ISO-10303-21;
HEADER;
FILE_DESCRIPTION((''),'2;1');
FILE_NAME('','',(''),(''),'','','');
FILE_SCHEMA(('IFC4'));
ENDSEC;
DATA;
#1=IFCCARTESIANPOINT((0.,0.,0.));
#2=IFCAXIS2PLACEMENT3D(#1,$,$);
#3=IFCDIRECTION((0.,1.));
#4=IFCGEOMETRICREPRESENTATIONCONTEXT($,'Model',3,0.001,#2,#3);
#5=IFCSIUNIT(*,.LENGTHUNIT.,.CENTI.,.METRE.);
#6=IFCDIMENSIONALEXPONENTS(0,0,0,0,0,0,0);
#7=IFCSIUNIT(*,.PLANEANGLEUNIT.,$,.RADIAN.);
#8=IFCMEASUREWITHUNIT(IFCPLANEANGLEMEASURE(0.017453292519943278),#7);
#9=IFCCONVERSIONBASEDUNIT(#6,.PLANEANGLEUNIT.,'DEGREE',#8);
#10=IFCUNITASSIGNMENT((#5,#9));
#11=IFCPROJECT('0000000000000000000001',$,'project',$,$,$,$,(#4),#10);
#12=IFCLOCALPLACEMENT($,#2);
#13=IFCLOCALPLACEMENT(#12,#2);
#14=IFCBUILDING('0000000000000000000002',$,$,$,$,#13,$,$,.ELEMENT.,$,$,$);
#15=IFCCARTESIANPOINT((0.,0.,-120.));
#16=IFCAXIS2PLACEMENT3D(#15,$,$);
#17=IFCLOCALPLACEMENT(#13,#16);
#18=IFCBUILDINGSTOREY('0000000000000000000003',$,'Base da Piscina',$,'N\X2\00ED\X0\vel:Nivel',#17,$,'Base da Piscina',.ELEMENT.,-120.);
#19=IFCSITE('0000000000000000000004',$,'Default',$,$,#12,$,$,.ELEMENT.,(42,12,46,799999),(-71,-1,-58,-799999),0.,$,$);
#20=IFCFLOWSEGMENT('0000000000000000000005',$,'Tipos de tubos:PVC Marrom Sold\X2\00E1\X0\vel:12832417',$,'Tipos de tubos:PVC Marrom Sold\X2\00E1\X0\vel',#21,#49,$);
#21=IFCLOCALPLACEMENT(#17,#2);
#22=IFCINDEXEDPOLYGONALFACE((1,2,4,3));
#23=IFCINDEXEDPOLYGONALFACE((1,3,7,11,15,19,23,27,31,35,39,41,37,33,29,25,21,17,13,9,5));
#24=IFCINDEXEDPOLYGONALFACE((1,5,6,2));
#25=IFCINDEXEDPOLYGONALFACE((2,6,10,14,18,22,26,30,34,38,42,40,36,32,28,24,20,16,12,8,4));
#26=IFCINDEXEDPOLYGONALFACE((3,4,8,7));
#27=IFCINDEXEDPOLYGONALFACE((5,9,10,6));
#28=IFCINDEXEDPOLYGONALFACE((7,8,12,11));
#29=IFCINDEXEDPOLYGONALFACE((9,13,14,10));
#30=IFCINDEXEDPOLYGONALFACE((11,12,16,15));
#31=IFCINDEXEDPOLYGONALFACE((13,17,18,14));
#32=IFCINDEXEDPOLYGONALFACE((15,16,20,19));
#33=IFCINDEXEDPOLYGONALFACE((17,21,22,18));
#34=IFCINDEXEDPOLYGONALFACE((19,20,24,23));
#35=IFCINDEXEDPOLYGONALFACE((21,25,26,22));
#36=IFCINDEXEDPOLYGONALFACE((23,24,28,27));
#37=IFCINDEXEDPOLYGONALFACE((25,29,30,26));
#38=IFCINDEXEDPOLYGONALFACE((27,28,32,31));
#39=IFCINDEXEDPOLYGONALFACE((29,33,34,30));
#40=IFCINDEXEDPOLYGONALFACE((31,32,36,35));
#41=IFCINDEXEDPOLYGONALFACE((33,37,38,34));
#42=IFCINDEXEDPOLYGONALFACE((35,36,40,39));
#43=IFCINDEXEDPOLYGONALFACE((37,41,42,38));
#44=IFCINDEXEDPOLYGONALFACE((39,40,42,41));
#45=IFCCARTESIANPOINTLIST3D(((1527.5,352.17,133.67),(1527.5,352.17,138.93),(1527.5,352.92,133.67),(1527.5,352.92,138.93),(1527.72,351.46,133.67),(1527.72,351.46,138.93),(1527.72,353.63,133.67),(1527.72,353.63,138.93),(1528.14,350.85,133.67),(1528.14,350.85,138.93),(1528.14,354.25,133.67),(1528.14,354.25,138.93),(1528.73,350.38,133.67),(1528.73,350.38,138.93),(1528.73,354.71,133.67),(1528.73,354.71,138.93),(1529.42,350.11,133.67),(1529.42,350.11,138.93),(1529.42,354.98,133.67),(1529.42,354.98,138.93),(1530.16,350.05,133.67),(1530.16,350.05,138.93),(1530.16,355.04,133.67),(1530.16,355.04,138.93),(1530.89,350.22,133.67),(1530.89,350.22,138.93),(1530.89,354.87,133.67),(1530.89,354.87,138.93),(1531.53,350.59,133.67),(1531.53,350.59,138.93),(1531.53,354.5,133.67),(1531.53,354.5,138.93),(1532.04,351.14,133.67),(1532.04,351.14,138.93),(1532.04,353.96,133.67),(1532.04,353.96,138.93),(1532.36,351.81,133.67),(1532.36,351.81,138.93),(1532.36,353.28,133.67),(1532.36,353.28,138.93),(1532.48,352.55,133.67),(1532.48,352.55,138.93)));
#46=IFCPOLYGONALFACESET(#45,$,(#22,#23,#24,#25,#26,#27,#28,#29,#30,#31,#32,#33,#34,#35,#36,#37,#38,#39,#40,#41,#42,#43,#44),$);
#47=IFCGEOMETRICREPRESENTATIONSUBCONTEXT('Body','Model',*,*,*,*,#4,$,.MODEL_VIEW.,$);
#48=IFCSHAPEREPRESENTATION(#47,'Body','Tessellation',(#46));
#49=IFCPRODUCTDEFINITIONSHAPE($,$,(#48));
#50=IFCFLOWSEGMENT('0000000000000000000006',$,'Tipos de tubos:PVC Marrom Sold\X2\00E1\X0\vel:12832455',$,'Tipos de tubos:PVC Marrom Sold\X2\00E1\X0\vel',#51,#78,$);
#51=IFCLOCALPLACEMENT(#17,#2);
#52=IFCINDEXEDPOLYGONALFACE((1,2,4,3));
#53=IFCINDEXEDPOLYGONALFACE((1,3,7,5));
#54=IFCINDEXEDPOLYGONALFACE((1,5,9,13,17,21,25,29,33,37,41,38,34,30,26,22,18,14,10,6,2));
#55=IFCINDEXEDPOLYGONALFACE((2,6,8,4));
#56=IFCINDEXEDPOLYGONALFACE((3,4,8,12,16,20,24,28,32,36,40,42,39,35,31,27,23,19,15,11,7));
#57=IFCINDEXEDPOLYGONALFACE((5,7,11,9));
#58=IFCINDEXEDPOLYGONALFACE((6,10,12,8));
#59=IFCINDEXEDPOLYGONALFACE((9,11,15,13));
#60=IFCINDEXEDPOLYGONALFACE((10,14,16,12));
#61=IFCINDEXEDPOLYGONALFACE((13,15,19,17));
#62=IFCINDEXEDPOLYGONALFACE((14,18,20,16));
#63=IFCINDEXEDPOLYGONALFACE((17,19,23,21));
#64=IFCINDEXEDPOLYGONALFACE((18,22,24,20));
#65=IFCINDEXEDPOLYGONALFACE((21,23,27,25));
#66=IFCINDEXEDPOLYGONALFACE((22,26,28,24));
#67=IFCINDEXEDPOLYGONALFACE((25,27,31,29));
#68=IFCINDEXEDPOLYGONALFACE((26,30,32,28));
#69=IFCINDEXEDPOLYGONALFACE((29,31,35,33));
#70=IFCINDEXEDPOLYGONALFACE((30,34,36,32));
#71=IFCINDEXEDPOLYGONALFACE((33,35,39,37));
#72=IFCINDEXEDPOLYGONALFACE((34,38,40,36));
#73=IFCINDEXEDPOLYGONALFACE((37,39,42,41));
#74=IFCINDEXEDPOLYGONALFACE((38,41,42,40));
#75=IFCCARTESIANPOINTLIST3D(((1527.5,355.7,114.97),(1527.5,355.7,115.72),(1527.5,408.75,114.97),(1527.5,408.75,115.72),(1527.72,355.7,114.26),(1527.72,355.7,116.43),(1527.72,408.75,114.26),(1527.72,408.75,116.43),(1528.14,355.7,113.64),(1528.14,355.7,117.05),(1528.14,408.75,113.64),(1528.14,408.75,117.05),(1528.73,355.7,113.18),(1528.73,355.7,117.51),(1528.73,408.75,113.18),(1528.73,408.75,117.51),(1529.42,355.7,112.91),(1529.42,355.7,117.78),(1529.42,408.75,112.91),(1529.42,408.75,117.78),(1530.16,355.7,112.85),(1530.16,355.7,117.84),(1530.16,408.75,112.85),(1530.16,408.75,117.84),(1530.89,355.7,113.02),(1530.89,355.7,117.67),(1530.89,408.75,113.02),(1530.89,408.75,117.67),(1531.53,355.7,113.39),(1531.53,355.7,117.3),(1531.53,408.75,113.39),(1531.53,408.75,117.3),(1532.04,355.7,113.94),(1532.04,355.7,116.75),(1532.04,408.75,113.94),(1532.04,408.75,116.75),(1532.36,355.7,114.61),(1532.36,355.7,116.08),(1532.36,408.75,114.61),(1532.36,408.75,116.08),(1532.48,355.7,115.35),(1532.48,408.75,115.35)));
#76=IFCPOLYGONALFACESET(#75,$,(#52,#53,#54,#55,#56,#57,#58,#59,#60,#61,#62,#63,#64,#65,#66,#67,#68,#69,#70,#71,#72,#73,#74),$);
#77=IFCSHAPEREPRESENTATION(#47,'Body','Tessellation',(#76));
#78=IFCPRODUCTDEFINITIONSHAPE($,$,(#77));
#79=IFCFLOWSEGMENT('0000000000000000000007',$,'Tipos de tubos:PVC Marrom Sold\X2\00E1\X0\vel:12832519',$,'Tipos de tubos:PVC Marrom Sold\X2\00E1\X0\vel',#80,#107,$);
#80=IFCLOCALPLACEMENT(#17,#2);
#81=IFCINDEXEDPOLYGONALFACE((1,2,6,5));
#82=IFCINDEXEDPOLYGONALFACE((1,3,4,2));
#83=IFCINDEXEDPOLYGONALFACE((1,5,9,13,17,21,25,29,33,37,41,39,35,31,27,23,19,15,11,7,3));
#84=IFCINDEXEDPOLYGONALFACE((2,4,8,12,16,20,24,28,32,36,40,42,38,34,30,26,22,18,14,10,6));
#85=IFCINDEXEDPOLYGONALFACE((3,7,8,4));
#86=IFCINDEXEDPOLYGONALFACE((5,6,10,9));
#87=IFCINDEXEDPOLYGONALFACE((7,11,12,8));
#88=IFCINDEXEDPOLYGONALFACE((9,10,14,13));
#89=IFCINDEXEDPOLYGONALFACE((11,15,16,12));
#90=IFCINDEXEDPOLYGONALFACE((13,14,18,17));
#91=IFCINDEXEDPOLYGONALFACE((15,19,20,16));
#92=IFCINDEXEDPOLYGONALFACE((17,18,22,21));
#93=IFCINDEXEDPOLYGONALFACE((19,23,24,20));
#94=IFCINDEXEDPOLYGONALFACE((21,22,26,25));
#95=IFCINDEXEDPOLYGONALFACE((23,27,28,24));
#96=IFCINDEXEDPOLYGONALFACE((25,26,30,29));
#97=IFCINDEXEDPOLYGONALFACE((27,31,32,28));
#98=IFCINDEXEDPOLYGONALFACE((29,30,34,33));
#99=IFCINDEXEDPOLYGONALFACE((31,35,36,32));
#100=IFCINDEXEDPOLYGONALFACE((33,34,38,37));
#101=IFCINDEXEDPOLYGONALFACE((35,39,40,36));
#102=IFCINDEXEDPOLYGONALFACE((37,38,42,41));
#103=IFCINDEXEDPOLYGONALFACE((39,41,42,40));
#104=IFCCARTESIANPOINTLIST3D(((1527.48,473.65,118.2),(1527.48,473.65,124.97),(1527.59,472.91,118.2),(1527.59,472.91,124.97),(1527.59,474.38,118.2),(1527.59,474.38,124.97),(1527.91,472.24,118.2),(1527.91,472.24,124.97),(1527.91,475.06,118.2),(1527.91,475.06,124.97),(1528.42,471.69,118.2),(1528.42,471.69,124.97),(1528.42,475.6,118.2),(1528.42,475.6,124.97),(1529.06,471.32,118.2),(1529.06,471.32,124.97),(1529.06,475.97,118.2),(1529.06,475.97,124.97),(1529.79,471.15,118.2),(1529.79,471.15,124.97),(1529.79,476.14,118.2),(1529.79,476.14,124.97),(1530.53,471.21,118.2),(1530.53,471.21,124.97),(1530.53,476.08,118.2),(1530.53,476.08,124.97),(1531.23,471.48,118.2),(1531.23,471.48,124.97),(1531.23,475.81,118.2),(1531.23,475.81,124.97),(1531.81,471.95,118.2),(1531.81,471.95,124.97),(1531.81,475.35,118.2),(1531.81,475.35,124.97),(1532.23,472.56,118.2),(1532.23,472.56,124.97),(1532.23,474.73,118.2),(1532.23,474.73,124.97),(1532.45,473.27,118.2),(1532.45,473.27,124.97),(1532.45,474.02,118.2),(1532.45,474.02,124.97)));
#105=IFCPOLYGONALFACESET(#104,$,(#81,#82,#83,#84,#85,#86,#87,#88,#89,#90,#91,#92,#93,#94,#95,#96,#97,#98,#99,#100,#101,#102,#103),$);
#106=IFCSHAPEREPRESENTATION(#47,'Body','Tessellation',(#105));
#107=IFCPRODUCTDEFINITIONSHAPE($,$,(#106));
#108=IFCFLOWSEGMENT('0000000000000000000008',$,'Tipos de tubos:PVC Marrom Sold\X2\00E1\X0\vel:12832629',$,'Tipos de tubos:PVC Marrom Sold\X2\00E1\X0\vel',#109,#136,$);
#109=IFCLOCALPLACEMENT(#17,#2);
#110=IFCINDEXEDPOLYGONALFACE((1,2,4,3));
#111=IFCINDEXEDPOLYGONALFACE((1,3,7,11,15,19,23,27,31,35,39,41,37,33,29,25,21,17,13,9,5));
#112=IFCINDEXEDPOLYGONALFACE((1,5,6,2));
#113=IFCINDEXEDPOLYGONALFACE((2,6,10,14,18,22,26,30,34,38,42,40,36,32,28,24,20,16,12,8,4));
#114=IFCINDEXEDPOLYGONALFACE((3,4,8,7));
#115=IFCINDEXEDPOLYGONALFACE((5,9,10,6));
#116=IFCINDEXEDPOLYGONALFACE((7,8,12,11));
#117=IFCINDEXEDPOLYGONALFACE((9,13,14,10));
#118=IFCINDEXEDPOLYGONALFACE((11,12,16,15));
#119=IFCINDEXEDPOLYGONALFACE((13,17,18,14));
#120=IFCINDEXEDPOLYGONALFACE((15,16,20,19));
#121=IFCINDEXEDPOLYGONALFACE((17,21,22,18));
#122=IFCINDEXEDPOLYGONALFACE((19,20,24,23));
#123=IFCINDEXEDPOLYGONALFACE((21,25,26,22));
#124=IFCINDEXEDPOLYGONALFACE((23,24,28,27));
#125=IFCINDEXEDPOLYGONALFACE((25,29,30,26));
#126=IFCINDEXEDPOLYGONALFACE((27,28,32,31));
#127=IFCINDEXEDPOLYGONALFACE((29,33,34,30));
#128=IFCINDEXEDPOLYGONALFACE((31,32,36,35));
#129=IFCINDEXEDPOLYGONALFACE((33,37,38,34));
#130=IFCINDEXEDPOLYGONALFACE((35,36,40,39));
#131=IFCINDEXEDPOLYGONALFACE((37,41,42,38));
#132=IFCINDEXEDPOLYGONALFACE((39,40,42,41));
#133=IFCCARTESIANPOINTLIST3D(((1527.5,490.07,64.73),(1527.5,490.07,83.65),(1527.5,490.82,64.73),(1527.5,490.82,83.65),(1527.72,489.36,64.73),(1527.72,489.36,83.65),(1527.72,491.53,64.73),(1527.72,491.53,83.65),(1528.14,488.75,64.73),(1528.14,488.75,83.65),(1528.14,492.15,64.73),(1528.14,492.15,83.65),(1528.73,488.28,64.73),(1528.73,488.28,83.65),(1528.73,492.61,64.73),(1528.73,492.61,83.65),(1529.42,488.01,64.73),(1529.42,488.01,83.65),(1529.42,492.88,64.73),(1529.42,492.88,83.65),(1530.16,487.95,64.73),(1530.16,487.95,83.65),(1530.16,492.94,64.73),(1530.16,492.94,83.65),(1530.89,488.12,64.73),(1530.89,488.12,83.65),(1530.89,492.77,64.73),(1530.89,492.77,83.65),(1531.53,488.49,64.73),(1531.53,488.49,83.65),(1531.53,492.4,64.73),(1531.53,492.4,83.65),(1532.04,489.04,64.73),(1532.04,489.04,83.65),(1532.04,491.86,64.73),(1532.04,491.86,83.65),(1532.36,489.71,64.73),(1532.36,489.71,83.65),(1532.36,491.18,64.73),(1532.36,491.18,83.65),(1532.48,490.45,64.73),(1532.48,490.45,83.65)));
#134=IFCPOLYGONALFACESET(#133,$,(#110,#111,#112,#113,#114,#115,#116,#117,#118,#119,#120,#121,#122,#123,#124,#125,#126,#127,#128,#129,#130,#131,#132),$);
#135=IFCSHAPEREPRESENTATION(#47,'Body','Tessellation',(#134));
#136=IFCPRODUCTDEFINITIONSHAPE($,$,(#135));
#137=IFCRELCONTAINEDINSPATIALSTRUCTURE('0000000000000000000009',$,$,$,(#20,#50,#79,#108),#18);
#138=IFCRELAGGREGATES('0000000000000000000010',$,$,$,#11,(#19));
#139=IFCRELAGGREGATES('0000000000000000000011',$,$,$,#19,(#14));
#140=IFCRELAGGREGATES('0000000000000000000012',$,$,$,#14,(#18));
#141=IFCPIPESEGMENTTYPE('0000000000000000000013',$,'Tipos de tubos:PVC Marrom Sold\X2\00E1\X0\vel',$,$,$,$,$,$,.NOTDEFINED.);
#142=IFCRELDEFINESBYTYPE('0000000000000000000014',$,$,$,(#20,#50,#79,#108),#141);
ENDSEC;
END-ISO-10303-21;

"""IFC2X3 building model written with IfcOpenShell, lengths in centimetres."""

from ifc_helpers import new_model, entity, si_unit, converted_unit, direction, frame, frame_2d, origin, origin_2d_with_axis, place, context, subcontext, project, spatial, circle, extrude, type_object, element, save


model = new_model("IFC2X3")

# Units and contexts
model_context = context("Model", 3, precision=0.001, world=origin(), true_north=direction((0.0, 1.0)))
body_context = subcontext(model_context, "Body", "Model", "MODEL_VIEW")
ifc_project = project(units=[si_unit("LENGTHUNIT", "METRE", prefix="CENTI"), converted_unit("PLANEANGLEUNIT", "DEGREE", entity("IfcPlaneAngleMeasure", 0.017453292519943278), si_unit("PLANEANGLEUNIT", "RADIAN"), dimensions=[0, 0, 0, 0, 0, 0, 0])], contexts=[model_context])

# Site, building, storey
site_placement = place(None, origin())
site = spatial("IfcSite", under=ifc_project, at=site_placement, Name="Default", CompositionType="ELEMENT", RefLatitude=(42, 12, 46, 799999), RefLongitude=(-71, -1, -58, -799999), RefElevation=0.0)
building_placement = place(site_placement, origin())
building = spatial("IfcBuilding", under=site, at=building_placement, CompositionType="ELEMENT")
storey_placement = place(building_placement, frame((0.0, 0.0, -120.0)))
storey = spatial("IfcBuildingStorey", under=building, at=storey_placement, Name="Base da Piscina", ObjectType="Nível:Nivel", LongName="Base da Piscina", CompositionType="ELEMENT", Elevation=-120.0)

# Flow segments
pipe_segment_type = type_object("IfcPipeSegmentType", Name="Tipos de tubos:PVC Marrom Soldável", PredefinedType="NOTDEFINED")
flow_segment_1_placement = place(storey_placement, origin())
element("IfcFlowSegment", 1, at=flow_segment_1_placement, inside=storey, type_object=pipe_segment_type, Name="Tipos de tubos:PVC Marrom Soldável:12832417", ObjectType="Tipos de tubos:PVC Marrom Soldável", context=body_context, shape_type="SweptSolid", body=[
    extrude(circle(Radius=2.5, at=origin_2d_with_axis()), frame((1529.98, 352.55, 133.67)), (0.0, 0.0, 1.0), 5.25),
])
flow_segment_2_placement = place(storey_placement, origin())
element("IfcFlowSegment", 2, at=flow_segment_2_placement, inside=storey, type_object=pipe_segment_type, Name="Tipos de tubos:PVC Marrom Soldável:12832455", ObjectType="Tipos de tubos:PVC Marrom Soldável", context=body_context, shape_type="SweptSolid", body=[
    extrude(circle(Radius=2.5, at=frame_2d((0.0, 0.0), x_axis=(1.0, 0.0))), frame((1529.98, 355.7, 115.35), z_axis=(0.0, 1.0, 0.0), x_axis=(1.0, 0.0, 0.0)), (0.0, 0.0, 1.0), 53.05),
])
flow_segment_3_placement = place(storey_placement, origin())
element("IfcFlowSegment", 3, at=flow_segment_3_placement, inside=storey, type_object=pipe_segment_type, Name="Tipos de tubos:PVC Marrom Soldável:12832519", ObjectType="Tipos de tubos:PVC Marrom Soldável", context=body_context, shape_type="SweptSolid", body=[
    extrude(circle(Radius=2.5, at=origin_2d_with_axis()), frame((1529.98, 473.65, 118.2), z_axis=(0.0, 0.0, 1.0), x_axis=(-1.0, 0.0, 0.0)), (0.0, 0.0, 1.0), 6.78),
])
flow_segment_4_placement = place(storey_placement, origin())
element("IfcFlowSegment", 4, at=flow_segment_4_placement, inside=storey, type_object=pipe_segment_type, Name="Tipos de tubos:PVC Marrom Soldável:12832629", ObjectType="Tipos de tubos:PVC Marrom Soldável", context=body_context, shape_type="SweptSolid", body=[
    extrude(circle(Radius=2.5, at=frame_2d((0.0, 0.0), x_axis=(1.0, 0.0))), frame((1529.98, 490.45, 64.73)), (0.0, 0.0, 1.0), 18.92),
])

save(model, "model.ifc")
